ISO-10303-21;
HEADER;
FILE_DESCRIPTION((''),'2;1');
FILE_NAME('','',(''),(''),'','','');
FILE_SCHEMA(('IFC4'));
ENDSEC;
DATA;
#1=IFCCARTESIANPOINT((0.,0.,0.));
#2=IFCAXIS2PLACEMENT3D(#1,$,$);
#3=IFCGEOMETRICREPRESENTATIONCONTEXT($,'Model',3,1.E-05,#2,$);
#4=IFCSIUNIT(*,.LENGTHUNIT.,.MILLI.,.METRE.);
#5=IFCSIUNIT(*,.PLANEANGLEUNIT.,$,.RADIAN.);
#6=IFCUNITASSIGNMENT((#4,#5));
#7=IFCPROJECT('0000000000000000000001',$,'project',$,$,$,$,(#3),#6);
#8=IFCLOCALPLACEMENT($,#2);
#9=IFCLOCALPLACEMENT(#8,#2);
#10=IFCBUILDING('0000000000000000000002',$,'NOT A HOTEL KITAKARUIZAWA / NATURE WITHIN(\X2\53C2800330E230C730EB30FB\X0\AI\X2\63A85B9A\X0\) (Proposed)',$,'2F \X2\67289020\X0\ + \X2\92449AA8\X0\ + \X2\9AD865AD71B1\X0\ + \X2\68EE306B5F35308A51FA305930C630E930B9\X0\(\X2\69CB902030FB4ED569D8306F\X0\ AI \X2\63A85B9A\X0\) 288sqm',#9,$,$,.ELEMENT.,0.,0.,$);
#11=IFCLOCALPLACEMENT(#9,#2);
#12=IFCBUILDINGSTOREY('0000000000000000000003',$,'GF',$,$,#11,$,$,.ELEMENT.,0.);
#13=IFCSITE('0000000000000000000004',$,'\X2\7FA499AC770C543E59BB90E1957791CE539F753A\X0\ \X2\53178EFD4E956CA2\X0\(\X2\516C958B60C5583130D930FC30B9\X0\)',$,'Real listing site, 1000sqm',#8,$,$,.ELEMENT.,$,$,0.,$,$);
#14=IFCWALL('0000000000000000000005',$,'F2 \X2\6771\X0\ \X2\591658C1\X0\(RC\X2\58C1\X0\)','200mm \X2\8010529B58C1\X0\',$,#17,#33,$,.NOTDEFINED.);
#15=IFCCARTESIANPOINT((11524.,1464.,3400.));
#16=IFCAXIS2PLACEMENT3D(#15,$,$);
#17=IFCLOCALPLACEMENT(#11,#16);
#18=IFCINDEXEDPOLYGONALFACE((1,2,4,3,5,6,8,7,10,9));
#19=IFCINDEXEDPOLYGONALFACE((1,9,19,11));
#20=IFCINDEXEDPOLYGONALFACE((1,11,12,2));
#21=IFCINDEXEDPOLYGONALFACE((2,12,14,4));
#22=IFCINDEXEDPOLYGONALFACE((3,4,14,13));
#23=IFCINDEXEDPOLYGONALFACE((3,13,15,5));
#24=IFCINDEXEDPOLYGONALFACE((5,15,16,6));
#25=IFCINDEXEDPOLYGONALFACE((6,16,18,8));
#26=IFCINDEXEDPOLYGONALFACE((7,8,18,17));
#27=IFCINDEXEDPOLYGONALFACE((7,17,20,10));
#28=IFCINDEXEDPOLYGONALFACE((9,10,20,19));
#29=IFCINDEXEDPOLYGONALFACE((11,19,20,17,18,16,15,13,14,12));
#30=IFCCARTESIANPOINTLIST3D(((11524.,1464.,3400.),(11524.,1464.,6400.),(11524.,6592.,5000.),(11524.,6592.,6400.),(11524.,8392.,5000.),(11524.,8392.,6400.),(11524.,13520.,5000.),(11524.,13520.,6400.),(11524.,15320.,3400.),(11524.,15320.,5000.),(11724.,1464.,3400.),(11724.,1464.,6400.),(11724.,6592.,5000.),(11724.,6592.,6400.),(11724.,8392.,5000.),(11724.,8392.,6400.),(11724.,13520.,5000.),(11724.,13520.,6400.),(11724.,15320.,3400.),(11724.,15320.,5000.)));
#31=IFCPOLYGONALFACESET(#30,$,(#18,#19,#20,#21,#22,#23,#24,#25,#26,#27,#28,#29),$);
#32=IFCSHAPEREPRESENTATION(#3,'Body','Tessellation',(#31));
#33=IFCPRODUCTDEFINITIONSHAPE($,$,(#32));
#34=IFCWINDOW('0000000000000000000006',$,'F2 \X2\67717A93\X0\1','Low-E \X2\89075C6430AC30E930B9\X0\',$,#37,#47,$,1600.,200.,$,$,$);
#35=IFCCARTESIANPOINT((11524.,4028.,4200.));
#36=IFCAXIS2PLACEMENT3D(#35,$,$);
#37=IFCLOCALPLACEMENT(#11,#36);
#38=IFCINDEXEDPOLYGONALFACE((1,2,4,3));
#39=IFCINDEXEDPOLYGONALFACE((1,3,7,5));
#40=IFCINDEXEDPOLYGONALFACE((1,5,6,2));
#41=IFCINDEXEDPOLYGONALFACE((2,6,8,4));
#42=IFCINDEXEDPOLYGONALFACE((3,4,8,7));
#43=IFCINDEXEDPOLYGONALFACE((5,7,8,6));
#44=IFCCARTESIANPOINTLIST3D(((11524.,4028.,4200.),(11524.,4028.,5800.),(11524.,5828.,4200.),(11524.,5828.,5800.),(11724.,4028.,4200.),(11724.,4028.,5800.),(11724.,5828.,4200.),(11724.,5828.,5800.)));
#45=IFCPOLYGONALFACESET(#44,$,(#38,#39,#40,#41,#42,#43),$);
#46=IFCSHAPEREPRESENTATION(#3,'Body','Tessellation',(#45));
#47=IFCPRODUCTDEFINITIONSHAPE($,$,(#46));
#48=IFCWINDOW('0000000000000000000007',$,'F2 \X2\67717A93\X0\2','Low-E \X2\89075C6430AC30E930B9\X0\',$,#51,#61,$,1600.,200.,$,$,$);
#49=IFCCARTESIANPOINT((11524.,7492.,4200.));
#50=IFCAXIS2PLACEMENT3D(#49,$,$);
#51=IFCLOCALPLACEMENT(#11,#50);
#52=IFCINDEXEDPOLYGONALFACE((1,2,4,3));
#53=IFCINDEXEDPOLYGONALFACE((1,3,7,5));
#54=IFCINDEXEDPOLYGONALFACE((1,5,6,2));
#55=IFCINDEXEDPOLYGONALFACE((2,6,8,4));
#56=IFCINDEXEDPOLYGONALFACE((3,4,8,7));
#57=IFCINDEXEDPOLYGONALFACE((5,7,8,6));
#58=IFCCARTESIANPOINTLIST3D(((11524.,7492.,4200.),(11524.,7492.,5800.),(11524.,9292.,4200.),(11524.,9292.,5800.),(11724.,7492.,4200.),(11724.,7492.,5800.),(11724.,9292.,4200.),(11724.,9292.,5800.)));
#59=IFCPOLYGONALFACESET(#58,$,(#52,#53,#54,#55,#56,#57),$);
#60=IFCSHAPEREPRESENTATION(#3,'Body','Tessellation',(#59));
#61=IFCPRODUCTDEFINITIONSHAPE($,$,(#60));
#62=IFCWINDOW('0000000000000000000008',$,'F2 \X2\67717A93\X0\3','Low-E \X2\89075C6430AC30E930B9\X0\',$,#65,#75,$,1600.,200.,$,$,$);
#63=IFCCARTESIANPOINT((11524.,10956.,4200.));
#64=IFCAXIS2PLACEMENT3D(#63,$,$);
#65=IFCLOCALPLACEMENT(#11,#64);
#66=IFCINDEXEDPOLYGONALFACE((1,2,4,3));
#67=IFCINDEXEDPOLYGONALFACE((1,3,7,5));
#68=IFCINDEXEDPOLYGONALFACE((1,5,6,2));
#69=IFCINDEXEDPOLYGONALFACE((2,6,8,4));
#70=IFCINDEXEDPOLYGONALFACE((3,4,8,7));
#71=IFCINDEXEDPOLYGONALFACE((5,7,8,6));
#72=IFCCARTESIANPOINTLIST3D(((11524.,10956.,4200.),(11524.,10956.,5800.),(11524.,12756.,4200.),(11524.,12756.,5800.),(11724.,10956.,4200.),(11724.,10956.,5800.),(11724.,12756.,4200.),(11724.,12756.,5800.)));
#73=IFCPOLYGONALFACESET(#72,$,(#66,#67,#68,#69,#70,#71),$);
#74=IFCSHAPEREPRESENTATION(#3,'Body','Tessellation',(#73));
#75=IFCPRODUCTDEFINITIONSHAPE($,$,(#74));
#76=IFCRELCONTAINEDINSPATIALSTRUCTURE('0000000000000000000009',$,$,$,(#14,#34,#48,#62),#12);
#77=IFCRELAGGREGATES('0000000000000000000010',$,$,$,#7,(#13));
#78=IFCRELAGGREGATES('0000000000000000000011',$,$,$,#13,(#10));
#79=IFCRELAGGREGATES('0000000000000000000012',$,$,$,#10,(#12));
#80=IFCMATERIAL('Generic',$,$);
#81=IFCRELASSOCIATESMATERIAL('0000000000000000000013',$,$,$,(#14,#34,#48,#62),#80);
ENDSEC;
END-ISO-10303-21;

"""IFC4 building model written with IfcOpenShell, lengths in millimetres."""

from ifc_helpers import new_model, si_unit, frame, frame_2d, origin, place, context, project, spatial, rectangle, extrude, material, element, fill, save


model = new_model("IFC4")

# Units and contexts
model_context = context("Model", 3, precision=1e-05, world=origin())
ifc_project = project(units=[si_unit("LENGTHUNIT", "METRE", prefix="MILLI"), si_unit("PLANEANGLEUNIT", "RADIAN")], contexts=[model_context])

# Site, building, storey
site_placement = place(None, origin())
site = spatial("IfcSite", under=ifc_project, at=site_placement, Name="群馬県吾妻郡長野原町 北軽井沢(公開情報ベース)", ObjectType="Real listing site, 1000sqm", CompositionType="ELEMENT", RefElevation=0.0)
building_placement = place(site_placement, origin())
building = spatial("IfcBuilding", under=site, at=building_placement, Name="NOT A HOTEL KITAKARUIZAWA / NATURE WITHIN(参考モデル・AI推定) (Proposed)", ObjectType="2F 木造 + 鉄骨 + 高断熱 + 森に張り出すテラス(構造・仕様は AI 推定) 288sqm", CompositionType="ELEMENT", ElevationOfRefHeight=0.0, ElevationOfTerrain=0.0)
storey_placement = place(building_placement, origin())
storey = spatial("IfcBuildingStorey", under=building, at=storey_placement, Name="GF", CompositionType="ELEMENT", Elevation=0.0)

# Shared definitions
ifc_material_1 = material(Name="Generic")

# Wall, openings, windows
wall_1_placement = place(storey_placement, frame((11524.0, 1464.0, 3400.0)))
wall_1 = element("IfcWall", 1, at=wall_1_placement, inside=storey, material=ifc_material_1, Name="F2 東 外壁(RC壁)", Description="200mm 耐力壁", PredefinedType="NOTDEFINED", context=model_context, shape_type="SweptSolid", body=[
    extrude(rectangle(XDim=200.0, YDim=13856.0, at=frame_2d((100.0, 6928.0))), frame((11524.0, 1464.0, 3400.0)), (0.0, 0.0, 1.0), 3000.0),
])
opening_1_placement = place(storey_placement, frame((11524.0, 4028.0, 4200.0)))
opening_1 = element("IfcOpeningElement", 2, at=opening_1_placement, cuts=wall_1, PredefinedType="NOTDEFINED", context=model_context, shape_type="SweptSolid", body=[
    extrude(rectangle(XDim=200.0, YDim=1800.0, at=frame_2d((100.0, 900.0))), frame((11524.0, 4028.0, 4200.0)), (0.0, 0.0, 1.0), 1600.0),
])
opening_2_placement = place(storey_placement, frame((11524.0, 7492.0, 4200.0)))
opening_2 = element("IfcOpeningElement", 3, at=opening_2_placement, cuts=wall_1, PredefinedType="NOTDEFINED", context=model_context, shape_type="SweptSolid", body=[
    extrude(rectangle(XDim=200.0, YDim=1800.0, at=frame_2d((100.0, 900.0))), frame((11524.0, 7492.0, 4200.0)), (0.0, 0.0, 1.0), 1600.0),
])
opening_3_placement = place(storey_placement, frame((11524.0, 10956.0, 4200.0)))
opening_3 = element("IfcOpeningElement", 4, at=opening_3_placement, cuts=wall_1, PredefinedType="NOTDEFINED", context=model_context, shape_type="SweptSolid", body=[
    extrude(rectangle(XDim=200.0, YDim=1800.0, at=frame_2d((100.0, 900.0))), frame((11524.0, 10956.0, 4200.0)), (0.0, 0.0, 1.0), 1600.0),
])
window_1_placement = place(storey_placement, frame((11524.0, 4028.0, 4200.0)))
window_1 = element("IfcWindow", 5, at=window_1_placement, inside=storey, material=ifc_material_1, Name="F2 東窓1", Description="Low-E 複層ガラス", OverallHeight=1600.0, OverallWidth=200.0, context=model_context, shape_type="SweptSolid", body=[
    extrude(rectangle(XDim=200.0, YDim=1800.0, at=frame_2d((100.0, 900.0))), frame((11524.0, 4028.0, 4200.0)), (0.0, 0.0, 1.0), 1600.0),
])
fill(opening_1, window_1)
window_2_placement = place(storey_placement, frame((11524.0, 7492.0, 4200.0)))
window_2 = element("IfcWindow", 6, at=window_2_placement, inside=storey, material=ifc_material_1, Name="F2 東窓2", Description="Low-E 複層ガラス", OverallHeight=1600.0, OverallWidth=200.0, context=model_context, shape_type="SweptSolid", body=[
    extrude(rectangle(XDim=200.0, YDim=1800.0, at=frame_2d((100.0, 900.0))), frame((11524.0, 7492.0, 4200.0)), (0.0, 0.0, 1.0), 1600.0),
])
fill(opening_2, window_2)
window_3_placement = place(storey_placement, frame((11524.0, 10956.0, 4200.0)))
window_3 = element("IfcWindow", 7, at=window_3_placement, inside=storey, material=ifc_material_1, Name="F2 東窓3", Description="Low-E 複層ガラス", OverallHeight=1600.0, OverallWidth=200.0, context=model_context, shape_type="SweptSolid", body=[
    extrude(rectangle(XDim=200.0, YDim=1800.0, at=frame_2d((100.0, 900.0))), frame((11524.0, 10956.0, 4200.0)), (0.0, 0.0, 1.0), 1600.0),
])
fill(opening_3, window_3)

save(model, "model.ifc")
